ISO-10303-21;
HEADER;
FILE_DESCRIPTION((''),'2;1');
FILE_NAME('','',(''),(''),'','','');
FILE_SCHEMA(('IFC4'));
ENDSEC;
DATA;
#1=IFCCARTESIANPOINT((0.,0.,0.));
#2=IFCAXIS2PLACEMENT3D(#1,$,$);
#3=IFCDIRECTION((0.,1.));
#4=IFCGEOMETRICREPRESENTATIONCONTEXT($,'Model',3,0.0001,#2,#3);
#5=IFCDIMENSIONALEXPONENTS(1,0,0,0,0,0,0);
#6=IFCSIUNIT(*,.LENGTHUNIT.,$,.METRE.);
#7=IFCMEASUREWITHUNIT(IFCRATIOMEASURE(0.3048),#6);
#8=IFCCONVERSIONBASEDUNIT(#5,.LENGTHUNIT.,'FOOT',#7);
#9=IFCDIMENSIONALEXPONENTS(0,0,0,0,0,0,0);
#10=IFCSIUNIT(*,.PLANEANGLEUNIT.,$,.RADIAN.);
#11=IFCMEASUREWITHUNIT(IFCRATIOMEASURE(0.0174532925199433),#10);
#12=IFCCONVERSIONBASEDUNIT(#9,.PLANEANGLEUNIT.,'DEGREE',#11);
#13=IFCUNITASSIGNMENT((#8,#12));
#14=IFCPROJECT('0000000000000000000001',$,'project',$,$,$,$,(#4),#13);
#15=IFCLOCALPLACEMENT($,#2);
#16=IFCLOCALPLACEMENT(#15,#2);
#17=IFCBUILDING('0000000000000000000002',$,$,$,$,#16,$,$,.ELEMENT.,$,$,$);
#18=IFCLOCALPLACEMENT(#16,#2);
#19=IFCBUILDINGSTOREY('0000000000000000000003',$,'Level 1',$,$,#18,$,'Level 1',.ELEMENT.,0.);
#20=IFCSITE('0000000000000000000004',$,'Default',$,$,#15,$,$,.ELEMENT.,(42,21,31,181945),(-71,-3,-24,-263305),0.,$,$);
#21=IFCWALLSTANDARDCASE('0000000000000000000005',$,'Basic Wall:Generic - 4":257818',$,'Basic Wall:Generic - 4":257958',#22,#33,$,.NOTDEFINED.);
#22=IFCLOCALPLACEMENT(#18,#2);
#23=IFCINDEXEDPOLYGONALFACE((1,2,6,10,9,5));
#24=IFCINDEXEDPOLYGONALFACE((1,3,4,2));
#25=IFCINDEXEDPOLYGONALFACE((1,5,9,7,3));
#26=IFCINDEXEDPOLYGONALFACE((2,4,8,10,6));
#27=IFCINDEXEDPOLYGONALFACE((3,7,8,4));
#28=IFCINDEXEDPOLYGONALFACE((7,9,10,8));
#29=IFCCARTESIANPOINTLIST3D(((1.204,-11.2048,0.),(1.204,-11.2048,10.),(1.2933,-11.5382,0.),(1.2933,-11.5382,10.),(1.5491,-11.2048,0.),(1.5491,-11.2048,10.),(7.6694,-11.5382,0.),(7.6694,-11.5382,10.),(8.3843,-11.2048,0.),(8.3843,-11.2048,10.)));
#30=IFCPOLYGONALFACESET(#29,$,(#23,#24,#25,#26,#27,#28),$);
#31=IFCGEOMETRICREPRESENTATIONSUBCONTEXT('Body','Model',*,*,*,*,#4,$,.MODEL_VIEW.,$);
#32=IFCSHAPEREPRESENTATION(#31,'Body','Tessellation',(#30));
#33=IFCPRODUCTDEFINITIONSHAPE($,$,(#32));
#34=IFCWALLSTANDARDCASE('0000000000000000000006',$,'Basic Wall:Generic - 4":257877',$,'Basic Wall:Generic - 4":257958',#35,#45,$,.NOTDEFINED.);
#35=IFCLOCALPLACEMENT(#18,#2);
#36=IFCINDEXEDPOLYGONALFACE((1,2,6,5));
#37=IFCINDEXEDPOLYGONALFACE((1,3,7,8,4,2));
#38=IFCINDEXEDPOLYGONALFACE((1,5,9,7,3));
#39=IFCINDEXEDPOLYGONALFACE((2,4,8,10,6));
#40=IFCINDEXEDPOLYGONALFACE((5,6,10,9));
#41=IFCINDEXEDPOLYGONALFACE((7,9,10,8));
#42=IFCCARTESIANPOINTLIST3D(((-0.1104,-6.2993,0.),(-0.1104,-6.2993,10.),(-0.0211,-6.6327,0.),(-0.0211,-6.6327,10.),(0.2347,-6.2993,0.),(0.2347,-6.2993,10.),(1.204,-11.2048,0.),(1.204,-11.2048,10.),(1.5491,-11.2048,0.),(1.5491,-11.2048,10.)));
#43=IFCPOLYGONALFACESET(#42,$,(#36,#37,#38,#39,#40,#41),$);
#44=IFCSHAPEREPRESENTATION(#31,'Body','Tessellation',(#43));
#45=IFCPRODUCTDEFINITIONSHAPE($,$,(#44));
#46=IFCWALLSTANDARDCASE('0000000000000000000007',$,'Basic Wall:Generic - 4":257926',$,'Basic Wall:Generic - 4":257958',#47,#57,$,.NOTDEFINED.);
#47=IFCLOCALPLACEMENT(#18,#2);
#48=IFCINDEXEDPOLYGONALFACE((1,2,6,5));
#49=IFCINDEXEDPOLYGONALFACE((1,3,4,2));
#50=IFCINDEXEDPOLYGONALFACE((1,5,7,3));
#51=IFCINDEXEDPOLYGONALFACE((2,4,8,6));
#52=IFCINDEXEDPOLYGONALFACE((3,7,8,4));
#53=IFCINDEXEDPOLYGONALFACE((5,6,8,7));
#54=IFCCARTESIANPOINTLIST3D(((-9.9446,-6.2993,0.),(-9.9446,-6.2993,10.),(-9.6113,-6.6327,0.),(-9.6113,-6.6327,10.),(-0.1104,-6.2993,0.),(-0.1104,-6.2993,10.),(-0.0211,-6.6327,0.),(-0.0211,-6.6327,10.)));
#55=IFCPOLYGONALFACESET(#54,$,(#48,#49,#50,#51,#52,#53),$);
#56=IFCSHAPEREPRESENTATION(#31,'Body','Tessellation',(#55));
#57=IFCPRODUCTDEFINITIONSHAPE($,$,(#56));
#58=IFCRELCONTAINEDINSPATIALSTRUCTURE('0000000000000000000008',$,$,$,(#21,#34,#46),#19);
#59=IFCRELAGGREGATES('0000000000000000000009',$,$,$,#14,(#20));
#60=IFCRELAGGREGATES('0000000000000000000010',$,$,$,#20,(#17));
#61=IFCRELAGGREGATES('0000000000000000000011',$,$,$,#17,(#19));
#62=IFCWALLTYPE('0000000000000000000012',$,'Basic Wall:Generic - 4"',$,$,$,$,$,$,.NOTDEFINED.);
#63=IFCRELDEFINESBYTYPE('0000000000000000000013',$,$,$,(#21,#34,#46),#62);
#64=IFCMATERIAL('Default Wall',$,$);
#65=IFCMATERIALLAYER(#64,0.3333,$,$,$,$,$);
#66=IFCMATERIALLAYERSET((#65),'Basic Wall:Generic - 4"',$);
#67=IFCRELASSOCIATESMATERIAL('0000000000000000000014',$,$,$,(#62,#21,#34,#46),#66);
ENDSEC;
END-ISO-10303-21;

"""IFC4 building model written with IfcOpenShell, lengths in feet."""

from ifc_helpers import new_model, entity, si_unit, converted_unit, direction, frame, origin, place, context, subcontext, project, spatial, polyline, outline, extrude, material, layer, layer_set, layer_usage, type_object, element, save


model = new_model("IFC4")

# Units and contexts
model_context = context("Model", 3, precision=0.0001, world=origin(), true_north=direction((0.0, 1.0)))
body_context = subcontext(model_context, "Body", "Model", "MODEL_VIEW")
ifc_project = project(units=[converted_unit("LENGTHUNIT", "FOOT", entity("IfcRatioMeasure", 0.3048), si_unit("LENGTHUNIT", "METRE"), dimensions=[1, 0, 0, 0, 0, 0, 0]), converted_unit("PLANEANGLEUNIT", "DEGREE", entity("IfcRatioMeasure", 0.0174532925199433), si_unit("PLANEANGLEUNIT", "RADIAN"), dimensions=[0, 0, 0, 0, 0, 0, 0])], contexts=[model_context])

# Site, building, storey
site_placement = place(None, origin())
site = spatial("IfcSite", under=ifc_project, at=site_placement, Name="Default", CompositionType="ELEMENT", RefLatitude=(42, 21, 31, 181945), RefLongitude=(-71, -3, -24, -263305), RefElevation=0.0)
building_placement = place(site_placement, origin())
building = spatial("IfcBuilding", under=site, at=building_placement, CompositionType="ELEMENT")
storey_placement = place(building_placement, origin())
storey = spatial("IfcBuildingStorey", under=building, at=storey_placement, Name="Level 1", LongName="Level 1", CompositionType="ELEMENT", Elevation=0.0)

# Walls
ifc_material = material(Name="Default Wall")
ifc_layer = layer(ifc_material, 0.3333)
ifc_layer_set = layer_set([ifc_layer], Name="Basic Wall:Generic - 4\"")
wall_type = type_object("IfcWallType", Name="Basic Wall:Generic - 4\"", PredefinedType="NOTDEFINED", material=ifc_layer_set)
ifc_layer_usage_1 = layer_usage(ifc_layer_set, "AXIS2", "NEGATIVE", 0.1667)
wall_1_placement = place(storey_placement, frame((8.3843, -11.3715, 0.0), z_axis=(0.0, 0.0, 1.0), x_axis=(-1.0, 0.0, 0.0)))
element("IfcWallStandardCase", 1, at=wall_1_placement, inside=storey, type_object=wall_type, material=ifc_layer_usage_1, Name="Basic Wall:Generic - 4\":257818", ObjectType="Basic Wall:Generic - 4\":257958", PredefinedType="NOTDEFINED", context=body_context, shape_type="SweptSolid", body=[
    extrude(outline(polyline([(7.1803, -0.1667), (7.0909, 0.1667), (0.7148, 0.1667), (0.0, -0.1667), (6.8352, -0.1667), (7.1803, -0.1667)])), origin(), (0.0, 0.0, 1.0), 10.0),
])
ifc_layer_usage_2 = layer_usage(ifc_layer_set, "AXIS2", "NEGATIVE", 0.1667)
wall_2_placement = place(storey_placement, frame((1.3881, -11.248, 0.0), z_axis=(0.0, 0.0, 1.0), x_axis=(-0.258819, 0.965926, 0.0)))
element("IfcWallStandardCase", 2, at=wall_2_placement, inside=storey, type_object=wall_type, material=ifc_layer_usage_2, Name="Basic Wall:Generic - 4\":257877", ObjectType="Basic Wall:Generic - 4\":257958", PredefinedType="NOTDEFINED", context=body_context, shape_type="SweptSolid", body=[
    extrude(outline(polyline([(5.0785, -0.1667), (5.1679, 0.1667), (4.8228, 0.1667), (0.0893, 0.1667), (0.0, -0.1667), (5.0785, -0.1667)])), origin(), (0.0, 0.0, 1.0), 10.0),
])
ifc_layer_usage_3 = layer_usage(ifc_layer_set, "AXIS2", "NEGATIVE", 0.1667)
wall_3_placement = place(storey_placement, frame((-0.0211, -6.466, 0.0), z_axis=(0.0, 0.0, 1.0), x_axis=(-1.0, 0.0, 0.0)))
element("IfcWallStandardCase", 3, at=wall_3_placement, inside=storey, type_object=wall_type, material=ifc_layer_usage_3, Name="Basic Wall:Generic - 4\":257926", ObjectType="Basic Wall:Generic - 4\":257958", PredefinedType="NOTDEFINED", context=body_context, shape_type="SweptSolid", body=[
    extrude(outline(polyline([(9.9235, -0.1667), (9.5902, 0.1667), (0.0, 0.1667), (0.0893, -0.1667), (9.9235, -0.1667)])), origin(), (0.0, 0.0, 1.0), 10.0),
])

save(model, "model.ifc")
